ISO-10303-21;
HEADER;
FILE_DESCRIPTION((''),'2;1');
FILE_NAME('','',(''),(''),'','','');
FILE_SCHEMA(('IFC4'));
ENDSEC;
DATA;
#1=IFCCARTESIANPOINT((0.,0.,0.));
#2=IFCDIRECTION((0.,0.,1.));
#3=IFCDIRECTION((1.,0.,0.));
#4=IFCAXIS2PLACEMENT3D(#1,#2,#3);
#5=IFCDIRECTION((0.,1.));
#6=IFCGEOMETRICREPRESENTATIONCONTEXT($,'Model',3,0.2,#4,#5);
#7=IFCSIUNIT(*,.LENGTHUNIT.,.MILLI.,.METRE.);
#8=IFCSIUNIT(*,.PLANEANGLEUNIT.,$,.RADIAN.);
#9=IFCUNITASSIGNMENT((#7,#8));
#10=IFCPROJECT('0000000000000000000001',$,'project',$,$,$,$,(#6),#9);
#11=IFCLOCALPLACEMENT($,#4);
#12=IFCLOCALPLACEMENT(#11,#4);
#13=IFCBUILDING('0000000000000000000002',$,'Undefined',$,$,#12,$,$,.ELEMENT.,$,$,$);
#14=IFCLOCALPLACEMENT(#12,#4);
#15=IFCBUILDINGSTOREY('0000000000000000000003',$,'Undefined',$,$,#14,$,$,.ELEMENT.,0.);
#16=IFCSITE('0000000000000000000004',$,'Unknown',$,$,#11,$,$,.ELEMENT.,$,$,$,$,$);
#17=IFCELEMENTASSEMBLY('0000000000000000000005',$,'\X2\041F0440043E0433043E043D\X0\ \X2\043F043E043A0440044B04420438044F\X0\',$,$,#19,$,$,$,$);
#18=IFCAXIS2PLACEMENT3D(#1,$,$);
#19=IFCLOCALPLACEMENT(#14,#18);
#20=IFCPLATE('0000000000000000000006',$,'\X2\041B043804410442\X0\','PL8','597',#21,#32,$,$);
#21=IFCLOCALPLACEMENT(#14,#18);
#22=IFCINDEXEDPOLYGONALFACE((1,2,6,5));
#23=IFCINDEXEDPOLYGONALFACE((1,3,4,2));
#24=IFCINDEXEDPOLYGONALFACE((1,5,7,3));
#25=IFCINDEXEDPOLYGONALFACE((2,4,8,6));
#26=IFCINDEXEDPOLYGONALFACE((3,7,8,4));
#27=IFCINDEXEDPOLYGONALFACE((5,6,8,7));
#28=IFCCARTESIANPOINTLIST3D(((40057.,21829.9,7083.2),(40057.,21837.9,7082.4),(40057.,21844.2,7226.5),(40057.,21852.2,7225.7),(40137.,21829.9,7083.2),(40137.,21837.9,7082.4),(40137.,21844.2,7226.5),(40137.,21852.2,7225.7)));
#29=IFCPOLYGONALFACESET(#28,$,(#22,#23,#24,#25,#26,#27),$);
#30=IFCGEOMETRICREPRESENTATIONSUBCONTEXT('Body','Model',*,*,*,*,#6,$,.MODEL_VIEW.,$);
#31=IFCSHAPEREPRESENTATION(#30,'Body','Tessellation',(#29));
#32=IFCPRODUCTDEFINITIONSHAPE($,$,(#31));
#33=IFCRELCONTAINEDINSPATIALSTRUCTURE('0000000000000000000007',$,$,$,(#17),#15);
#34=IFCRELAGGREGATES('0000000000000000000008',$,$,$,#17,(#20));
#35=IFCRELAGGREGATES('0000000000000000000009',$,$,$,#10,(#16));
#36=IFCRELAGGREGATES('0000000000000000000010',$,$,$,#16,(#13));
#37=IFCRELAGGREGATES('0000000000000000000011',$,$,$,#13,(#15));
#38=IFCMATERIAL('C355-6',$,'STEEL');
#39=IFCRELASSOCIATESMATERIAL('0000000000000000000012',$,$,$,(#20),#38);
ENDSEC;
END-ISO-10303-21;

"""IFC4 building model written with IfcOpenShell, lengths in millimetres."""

from ifc_helpers import new_model, si_unit, direction, frame, origin_with_axes, place, context, subcontext, project, spatial, line, indexed_curve, outline, extrude, material, element, aggregate, save


model = new_model("IFC4")

# Units and contexts
model_context = context("Model", 3, precision=0.2, world=origin_with_axes(), true_north=direction((0.0, 1.0)))
body_context = subcontext(model_context, "Body", "Model", "MODEL_VIEW")
ifc_project = project(units=[si_unit("LENGTHUNIT", "METRE", prefix="MILLI"), si_unit("PLANEANGLEUNIT", "RADIAN")], contexts=[model_context])

# Site, building, storey
site_placement = place(None, origin_with_axes())
site = spatial("IfcSite", under=ifc_project, at=site_placement, Name="Unknown", CompositionType="ELEMENT")
building_placement = place(site_placement, origin_with_axes())
building = spatial("IfcBuilding", under=site, at=building_placement, Name="Undefined", CompositionType="ELEMENT")
storey_placement = place(building_placement, origin_with_axes())
storey = spatial("IfcBuildingStorey", under=building, at=storey_placement, Name="Undefined", CompositionType="ELEMENT", Elevation=0.0)

# Shared definitions
ifc_material_1 = material(Name="C355-6", Category="STEEL")

# Element assembly, plate
assembly_1_placement = place(storey_placement, frame((46000.0, 21841.0, 7154.4), z_axis=(0.0, -0.995037, 0.099504), x_axis=(-1.0, 0.0, 0.0)))
assembly_1 = element("IfcElementAssembly", 1, at=assembly_1_placement, inside=storey, Name="Прогон покрытия")
plate_1_placement = place(assembly_1_placement, frame((5943.0, 72.0, 0.0), z_axis=(0.0, 0.0, 1.0), x_axis=(-1.0, 0.0, 0.0)))
plate_1 = element("IfcPlate", 2, at=plate_1_placement, material=ifc_material_1, Name="Лист", Description="PL8", ObjectType="597", context=body_context, shape_type="SolidModel", body=[
    extrude(outline(indexed_curve([(0.0, 0.0), (80.0, 0.0), (80.0, 144.0), (0.0, 144.0)], segments=[line(1, 2, 3, 4, 1)])), frame((0.0, 0.0, 4.0), z_axis=(0.0, 0.0, 1.0), x_axis=(1.0, 0.0, 0.0)), (0.0, 0.0, -1.0), 8.0),
])
aggregate(assembly_1, [plate_1])

save(model, "model.ifc")
